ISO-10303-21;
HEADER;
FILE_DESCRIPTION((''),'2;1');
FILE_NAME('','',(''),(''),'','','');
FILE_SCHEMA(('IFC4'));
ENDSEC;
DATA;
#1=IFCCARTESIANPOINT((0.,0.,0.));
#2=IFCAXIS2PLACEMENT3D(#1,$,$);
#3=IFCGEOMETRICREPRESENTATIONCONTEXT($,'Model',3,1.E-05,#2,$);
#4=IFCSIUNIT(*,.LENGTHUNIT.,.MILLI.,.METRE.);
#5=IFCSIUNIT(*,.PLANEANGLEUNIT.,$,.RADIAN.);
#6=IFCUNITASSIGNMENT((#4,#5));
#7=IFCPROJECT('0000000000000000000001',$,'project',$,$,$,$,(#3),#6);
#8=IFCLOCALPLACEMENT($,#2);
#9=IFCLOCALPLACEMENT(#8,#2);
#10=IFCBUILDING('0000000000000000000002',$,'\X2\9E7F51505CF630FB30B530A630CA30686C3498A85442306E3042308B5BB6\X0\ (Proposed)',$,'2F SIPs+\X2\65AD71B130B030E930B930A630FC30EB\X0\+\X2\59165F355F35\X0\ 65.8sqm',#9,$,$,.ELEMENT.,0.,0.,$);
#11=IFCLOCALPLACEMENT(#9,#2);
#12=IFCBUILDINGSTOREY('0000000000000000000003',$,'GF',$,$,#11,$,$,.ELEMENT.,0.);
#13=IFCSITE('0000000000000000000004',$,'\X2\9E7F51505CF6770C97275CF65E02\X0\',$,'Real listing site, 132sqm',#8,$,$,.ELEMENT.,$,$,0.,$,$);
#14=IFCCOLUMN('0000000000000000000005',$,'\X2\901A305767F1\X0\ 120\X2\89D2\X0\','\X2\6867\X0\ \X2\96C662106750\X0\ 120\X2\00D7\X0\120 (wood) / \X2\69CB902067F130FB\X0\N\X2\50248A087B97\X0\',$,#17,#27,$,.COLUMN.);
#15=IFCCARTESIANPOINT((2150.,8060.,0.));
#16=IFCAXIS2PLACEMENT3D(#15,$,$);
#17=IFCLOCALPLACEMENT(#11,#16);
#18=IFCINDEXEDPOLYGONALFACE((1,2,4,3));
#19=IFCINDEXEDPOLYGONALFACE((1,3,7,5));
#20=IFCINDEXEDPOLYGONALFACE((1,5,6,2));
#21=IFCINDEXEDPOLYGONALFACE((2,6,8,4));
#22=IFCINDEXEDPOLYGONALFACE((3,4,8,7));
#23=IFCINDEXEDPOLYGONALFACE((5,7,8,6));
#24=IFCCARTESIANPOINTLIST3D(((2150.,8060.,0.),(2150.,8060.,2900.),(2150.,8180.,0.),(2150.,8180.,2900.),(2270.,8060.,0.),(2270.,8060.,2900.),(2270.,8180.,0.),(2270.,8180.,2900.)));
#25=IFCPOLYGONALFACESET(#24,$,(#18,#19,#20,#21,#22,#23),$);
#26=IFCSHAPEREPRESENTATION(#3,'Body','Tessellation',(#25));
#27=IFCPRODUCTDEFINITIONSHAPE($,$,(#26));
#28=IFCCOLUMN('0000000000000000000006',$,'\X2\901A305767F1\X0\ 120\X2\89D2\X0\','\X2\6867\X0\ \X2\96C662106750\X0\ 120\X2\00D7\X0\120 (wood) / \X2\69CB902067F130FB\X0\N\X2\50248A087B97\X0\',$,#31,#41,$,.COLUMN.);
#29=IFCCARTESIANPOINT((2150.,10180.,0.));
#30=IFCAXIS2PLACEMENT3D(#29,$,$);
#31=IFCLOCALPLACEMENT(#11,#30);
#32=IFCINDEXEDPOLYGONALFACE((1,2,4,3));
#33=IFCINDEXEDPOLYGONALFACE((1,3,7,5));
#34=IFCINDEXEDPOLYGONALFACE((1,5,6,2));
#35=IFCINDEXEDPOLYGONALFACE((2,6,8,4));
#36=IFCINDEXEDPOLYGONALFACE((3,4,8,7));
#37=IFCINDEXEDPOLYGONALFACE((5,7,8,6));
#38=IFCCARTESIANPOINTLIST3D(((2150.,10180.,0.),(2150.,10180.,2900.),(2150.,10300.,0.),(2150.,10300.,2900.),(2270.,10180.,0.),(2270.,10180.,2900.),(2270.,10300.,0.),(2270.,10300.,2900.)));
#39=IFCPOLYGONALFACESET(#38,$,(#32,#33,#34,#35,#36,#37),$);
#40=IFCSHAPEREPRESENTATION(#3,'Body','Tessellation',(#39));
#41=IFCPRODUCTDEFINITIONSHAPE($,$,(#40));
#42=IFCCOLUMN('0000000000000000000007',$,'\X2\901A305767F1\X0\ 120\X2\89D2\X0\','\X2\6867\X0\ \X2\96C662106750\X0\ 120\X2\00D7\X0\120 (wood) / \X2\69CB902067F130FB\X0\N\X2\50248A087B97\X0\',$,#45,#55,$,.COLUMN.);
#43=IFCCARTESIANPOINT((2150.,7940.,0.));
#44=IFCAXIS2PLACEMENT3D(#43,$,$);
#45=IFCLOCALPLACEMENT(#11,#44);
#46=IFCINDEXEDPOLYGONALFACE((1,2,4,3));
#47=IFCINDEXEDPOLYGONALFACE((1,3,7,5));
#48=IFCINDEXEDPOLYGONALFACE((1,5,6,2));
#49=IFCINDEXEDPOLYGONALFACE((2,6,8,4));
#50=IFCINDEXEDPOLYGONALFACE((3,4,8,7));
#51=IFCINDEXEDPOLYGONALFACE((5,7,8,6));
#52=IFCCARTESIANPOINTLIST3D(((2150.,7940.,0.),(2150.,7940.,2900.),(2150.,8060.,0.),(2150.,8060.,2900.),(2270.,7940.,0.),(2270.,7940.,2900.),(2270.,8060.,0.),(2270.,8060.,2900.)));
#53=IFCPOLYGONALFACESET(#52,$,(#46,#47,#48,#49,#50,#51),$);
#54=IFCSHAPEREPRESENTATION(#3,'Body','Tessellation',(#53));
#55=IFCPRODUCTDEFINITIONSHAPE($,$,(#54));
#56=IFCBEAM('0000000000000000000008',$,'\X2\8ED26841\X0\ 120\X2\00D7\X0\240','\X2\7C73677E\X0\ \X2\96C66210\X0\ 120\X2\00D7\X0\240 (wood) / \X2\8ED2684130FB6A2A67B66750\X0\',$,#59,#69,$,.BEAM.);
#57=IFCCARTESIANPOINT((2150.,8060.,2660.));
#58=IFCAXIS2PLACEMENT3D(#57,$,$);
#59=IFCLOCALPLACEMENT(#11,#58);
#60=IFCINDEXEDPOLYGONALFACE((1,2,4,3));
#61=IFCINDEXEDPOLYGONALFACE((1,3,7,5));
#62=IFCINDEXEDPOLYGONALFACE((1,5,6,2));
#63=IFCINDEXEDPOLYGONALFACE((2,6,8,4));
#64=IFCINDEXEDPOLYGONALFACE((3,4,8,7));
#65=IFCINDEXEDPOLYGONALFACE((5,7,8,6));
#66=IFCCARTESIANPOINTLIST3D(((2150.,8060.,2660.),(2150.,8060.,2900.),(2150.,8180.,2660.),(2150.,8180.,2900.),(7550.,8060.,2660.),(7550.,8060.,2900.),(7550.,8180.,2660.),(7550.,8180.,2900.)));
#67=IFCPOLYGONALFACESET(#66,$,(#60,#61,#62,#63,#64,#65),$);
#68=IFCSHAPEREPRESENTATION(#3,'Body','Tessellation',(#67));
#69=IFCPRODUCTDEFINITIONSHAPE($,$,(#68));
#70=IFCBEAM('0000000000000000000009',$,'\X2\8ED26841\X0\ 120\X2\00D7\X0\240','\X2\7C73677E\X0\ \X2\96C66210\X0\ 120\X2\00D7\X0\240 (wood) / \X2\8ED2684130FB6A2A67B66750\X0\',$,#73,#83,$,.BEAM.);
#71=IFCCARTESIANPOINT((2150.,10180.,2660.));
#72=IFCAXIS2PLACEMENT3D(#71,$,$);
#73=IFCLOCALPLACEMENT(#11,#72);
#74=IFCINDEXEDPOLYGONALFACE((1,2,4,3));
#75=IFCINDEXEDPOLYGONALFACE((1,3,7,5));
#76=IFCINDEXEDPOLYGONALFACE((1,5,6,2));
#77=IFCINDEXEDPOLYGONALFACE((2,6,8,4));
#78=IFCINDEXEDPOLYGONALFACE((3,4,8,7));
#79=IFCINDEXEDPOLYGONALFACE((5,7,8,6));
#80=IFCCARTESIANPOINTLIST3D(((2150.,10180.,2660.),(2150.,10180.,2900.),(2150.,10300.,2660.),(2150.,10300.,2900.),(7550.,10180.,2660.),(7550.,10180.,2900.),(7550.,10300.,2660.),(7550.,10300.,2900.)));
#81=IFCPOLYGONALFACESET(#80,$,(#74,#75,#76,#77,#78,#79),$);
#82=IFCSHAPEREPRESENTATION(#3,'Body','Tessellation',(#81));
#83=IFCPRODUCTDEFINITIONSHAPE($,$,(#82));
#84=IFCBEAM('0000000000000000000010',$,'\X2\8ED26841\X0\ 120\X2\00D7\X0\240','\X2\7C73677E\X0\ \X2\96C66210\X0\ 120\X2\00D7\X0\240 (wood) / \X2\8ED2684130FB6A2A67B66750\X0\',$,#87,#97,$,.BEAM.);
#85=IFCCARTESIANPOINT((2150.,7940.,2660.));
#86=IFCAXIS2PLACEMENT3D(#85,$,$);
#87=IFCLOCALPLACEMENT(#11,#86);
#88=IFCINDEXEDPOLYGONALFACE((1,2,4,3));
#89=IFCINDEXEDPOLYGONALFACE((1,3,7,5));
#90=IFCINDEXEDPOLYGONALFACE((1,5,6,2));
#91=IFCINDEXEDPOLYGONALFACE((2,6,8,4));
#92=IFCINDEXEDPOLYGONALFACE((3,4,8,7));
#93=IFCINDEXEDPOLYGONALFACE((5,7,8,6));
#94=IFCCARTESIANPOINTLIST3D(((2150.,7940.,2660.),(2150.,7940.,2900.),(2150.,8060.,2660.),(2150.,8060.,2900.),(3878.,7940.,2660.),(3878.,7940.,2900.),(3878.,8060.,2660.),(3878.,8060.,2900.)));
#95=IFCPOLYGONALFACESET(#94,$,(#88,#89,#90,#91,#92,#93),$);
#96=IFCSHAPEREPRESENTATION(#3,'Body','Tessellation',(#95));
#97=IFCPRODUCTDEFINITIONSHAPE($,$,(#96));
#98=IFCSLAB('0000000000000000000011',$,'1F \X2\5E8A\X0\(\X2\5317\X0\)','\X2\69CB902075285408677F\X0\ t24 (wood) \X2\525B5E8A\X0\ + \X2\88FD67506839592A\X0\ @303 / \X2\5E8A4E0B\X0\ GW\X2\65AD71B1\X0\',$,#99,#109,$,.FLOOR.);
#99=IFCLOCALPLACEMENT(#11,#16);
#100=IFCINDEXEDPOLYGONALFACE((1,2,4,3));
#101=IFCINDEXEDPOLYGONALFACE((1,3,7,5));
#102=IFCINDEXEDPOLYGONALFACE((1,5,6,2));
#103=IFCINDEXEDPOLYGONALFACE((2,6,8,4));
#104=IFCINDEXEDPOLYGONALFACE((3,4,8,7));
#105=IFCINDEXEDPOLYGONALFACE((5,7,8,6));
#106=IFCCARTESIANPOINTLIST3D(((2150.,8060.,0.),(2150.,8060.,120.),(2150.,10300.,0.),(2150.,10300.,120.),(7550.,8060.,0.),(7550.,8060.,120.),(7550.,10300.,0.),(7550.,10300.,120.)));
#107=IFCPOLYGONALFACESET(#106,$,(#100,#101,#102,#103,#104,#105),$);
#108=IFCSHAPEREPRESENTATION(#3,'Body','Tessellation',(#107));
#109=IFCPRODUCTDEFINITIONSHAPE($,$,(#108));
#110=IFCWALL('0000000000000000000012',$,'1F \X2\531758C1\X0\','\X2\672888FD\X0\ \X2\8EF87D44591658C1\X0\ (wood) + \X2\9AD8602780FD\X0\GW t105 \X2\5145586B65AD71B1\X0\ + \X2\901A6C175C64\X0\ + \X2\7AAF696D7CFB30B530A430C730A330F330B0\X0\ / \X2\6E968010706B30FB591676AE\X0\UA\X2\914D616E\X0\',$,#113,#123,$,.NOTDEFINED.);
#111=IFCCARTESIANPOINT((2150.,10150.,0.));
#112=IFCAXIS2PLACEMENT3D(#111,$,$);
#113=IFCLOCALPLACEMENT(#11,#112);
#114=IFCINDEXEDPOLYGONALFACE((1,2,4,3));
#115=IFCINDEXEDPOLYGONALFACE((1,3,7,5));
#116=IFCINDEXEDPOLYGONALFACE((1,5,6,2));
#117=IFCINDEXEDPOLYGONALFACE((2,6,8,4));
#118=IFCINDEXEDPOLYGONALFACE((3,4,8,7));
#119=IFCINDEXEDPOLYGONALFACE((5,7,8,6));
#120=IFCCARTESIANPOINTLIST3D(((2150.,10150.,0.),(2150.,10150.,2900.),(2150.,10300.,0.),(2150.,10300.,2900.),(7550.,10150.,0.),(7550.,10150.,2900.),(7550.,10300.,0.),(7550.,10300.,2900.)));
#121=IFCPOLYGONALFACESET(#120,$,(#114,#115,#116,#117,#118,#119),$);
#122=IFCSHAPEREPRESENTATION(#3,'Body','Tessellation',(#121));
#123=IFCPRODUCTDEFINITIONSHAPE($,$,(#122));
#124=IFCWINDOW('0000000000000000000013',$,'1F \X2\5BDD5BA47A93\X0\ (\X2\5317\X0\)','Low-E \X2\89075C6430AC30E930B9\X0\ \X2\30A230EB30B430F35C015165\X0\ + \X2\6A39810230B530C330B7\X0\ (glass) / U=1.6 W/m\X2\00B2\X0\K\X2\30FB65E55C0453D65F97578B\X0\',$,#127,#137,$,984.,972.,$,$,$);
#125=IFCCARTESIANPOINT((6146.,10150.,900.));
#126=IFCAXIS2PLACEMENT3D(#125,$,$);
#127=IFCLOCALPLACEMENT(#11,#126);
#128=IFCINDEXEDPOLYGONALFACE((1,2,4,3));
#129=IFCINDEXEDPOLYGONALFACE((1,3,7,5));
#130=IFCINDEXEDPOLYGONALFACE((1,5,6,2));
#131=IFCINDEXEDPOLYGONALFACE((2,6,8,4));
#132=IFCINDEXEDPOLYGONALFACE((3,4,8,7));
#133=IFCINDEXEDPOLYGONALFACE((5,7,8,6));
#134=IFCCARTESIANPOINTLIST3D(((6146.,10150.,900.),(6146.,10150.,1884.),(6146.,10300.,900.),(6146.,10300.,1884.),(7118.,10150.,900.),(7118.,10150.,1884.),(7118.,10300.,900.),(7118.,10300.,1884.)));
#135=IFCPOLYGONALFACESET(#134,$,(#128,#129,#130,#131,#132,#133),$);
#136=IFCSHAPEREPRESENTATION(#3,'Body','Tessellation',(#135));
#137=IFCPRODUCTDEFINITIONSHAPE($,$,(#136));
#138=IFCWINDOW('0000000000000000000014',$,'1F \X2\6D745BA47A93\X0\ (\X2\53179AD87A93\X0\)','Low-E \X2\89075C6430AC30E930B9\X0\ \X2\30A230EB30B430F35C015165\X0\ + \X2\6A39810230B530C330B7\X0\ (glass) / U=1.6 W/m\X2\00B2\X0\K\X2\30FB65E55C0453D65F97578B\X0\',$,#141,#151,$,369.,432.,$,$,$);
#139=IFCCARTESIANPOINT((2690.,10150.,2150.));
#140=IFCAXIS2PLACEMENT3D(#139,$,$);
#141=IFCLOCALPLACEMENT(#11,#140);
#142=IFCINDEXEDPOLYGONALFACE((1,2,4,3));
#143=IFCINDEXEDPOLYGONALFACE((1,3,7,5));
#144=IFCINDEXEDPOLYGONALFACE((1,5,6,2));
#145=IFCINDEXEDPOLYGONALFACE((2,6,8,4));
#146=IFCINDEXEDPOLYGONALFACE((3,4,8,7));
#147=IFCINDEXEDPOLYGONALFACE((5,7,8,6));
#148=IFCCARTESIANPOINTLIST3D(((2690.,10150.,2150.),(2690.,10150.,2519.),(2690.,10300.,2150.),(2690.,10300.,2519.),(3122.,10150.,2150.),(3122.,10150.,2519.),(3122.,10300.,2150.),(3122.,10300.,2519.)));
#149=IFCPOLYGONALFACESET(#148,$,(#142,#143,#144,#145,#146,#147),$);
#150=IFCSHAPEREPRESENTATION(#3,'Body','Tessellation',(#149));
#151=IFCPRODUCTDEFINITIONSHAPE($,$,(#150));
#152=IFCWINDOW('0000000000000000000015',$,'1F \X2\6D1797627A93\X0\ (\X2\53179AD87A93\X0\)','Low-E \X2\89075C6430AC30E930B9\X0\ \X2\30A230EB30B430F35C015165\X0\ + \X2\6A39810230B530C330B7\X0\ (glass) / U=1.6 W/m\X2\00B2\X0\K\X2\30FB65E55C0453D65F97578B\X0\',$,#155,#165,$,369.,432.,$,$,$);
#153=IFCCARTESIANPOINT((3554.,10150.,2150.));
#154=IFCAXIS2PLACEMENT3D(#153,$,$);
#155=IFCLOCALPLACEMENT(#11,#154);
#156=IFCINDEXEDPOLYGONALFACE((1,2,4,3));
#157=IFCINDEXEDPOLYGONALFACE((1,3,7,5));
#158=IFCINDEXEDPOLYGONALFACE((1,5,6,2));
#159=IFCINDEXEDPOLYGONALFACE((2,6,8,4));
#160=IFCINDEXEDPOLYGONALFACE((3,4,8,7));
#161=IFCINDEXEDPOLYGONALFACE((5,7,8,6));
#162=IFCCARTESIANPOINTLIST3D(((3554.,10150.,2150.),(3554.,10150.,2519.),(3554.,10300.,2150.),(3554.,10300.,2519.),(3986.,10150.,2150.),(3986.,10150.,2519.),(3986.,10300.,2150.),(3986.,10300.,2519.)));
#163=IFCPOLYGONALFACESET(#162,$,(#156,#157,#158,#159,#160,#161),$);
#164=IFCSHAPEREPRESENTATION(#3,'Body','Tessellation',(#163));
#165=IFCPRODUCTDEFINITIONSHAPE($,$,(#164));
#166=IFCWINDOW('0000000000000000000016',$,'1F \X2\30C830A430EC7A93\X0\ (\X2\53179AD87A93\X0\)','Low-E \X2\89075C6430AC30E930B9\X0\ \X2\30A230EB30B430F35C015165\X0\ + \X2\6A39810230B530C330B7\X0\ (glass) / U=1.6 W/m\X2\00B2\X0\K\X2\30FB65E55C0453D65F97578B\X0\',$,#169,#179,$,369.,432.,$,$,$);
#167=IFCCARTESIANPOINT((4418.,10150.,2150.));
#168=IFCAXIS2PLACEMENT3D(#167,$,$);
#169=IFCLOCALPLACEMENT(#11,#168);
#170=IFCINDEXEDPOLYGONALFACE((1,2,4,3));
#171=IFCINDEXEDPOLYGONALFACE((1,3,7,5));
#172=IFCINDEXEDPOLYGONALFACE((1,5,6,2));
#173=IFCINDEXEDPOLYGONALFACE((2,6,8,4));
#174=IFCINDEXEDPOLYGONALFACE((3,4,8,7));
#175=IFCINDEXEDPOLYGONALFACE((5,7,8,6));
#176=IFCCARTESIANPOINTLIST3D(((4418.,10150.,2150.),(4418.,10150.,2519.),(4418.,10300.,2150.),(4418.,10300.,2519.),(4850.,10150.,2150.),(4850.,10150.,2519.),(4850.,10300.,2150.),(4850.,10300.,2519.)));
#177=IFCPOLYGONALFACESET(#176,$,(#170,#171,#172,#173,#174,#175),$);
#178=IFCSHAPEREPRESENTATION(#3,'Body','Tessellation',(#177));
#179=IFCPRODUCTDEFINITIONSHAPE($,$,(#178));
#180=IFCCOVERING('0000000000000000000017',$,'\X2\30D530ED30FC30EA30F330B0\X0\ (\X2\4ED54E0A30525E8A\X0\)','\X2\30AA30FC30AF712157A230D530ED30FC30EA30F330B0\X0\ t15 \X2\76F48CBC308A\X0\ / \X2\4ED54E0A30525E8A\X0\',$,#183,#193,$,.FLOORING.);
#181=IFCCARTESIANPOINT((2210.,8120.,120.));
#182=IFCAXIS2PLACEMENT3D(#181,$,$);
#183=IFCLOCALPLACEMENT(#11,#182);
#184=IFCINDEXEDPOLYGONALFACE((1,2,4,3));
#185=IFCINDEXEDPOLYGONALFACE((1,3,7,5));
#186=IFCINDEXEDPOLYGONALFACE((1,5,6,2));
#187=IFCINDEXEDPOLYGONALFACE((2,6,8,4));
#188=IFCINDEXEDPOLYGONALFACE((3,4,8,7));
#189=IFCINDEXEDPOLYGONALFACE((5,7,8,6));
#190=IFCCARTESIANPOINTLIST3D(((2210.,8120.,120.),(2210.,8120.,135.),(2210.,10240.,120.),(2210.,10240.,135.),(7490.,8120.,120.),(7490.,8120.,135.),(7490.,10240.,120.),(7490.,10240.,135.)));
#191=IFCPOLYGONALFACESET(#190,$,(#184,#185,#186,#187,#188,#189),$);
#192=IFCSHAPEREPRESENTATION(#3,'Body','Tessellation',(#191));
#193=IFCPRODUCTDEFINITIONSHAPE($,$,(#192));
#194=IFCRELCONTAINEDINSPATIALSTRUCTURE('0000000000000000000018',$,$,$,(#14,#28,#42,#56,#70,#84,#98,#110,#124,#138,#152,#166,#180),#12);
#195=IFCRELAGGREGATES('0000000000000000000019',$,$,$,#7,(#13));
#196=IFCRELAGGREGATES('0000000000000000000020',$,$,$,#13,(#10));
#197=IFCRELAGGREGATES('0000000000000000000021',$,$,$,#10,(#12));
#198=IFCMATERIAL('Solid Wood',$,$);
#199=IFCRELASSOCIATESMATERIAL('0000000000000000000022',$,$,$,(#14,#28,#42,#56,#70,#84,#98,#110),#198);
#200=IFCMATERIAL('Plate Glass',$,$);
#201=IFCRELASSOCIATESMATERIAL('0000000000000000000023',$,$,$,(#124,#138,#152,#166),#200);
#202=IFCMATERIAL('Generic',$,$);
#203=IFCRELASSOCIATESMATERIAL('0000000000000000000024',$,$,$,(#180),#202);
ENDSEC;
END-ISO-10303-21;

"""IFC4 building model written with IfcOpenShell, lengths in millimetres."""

from ifc_helpers import new_model, si_unit, frame, frame_2d, origin, place, context, project, spatial, rectangle, extrude, material, element, fill, save


model = new_model("IFC4")

# Units and contexts
model_context = context("Model", 3, precision=1e-05, world=origin())
ifc_project = project(units=[si_unit("LENGTHUNIT", "METRE", prefix="MILLI"), si_unit("PLANEANGLEUNIT", "RADIAN")], contexts=[model_context])

# Site, building, storey
site_placement = place(None, origin())
site = spatial("IfcSite", under=ifc_project, at=site_placement, Name="鹿児島県霧島市", ObjectType="Real listing site, 132sqm", CompositionType="ELEMENT", RefElevation=0.0)
building_placement = place(site_placement, origin())
building = spatial("IfcBuilding", under=site, at=building_placement, Name="鹿児島・サウナと水風呂のある家 (Proposed)", ObjectType="2F SIPs+断熱グラスウール+外張張 65.8sqm", CompositionType="ELEMENT", ElevationOfRefHeight=0.0, ElevationOfTerrain=0.0)
storey_placement = place(building_placement, origin())
storey = spatial("IfcBuildingStorey", under=building, at=storey_placement, Name="GF", CompositionType="ELEMENT", Elevation=0.0)

# Columns
ifc_material_1 = material(Name="Solid Wood")
column_1_placement = place(storey_placement, frame((2150.0, 8060.0, 0.0)))
element("IfcColumn", 1, at=column_1_placement, inside=storey, material=ifc_material_1, Name="通し柱 120角", Description="桧 集成材 120×120 (wood) / 構造柱・N値計算", PredefinedType="COLUMN", context=model_context, shape_type="SweptSolid", body=[
    extrude(rectangle(XDim=120.0, YDim=120.0, at=frame_2d((60.0, 60.0))), frame((2150.0, 8060.0, 0.0)), (0.0, 0.0, 1.0), 2900.0),
])
column_2_placement = place(storey_placement, frame((2150.0, 10180.0, 0.0)))
element("IfcColumn", 2, at=column_2_placement, inside=storey, material=ifc_material_1, Name="通し柱 120角", Description="桧 集成材 120×120 (wood) / 構造柱・N値計算", PredefinedType="COLUMN", context=model_context, shape_type="SweptSolid", body=[
    extrude(rectangle(XDim=120.0, YDim=120.0, at=frame_2d((60.0, 60.0))), frame((2150.0, 10180.0, 0.0)), (0.0, 0.0, 1.0), 2900.0),
])
column_3_placement = place(storey_placement, frame((2150.0, 7940.0, 0.0)))
element("IfcColumn", 3, at=column_3_placement, inside=storey, material=ifc_material_1, Name="通し柱 120角", Description="桧 集成材 120×120 (wood) / 構造柱・N値計算", PredefinedType="COLUMN", context=model_context, shape_type="SweptSolid", body=[
    extrude(rectangle(XDim=120.0, YDim=120.0, at=frame_2d((60.0, 60.0))), frame((2150.0, 7940.0, 0.0)), (0.0, 0.0, 1.0), 2900.0),
])

# Beams
beam_1_placement = place(storey_placement, frame((2150.0, 8060.0, 2660.0)))
element("IfcBeam", 4, at=beam_1_placement, inside=storey, material=ifc_material_1, Name="軒桁 120×240", Description="米松 集成 120×240 (wood) / 軒桁・横架材", PredefinedType="BEAM", context=model_context, shape_type="SweptSolid", body=[
    extrude(rectangle(XDim=5400.0, YDim=120.0, at=frame_2d((2700.0, 60.0))), frame((2150.0, 8060.0, 2660.0)), (0.0, 0.0, 1.0), 240.0),
])
beam_2_placement = place(storey_placement, frame((2150.0, 10180.0, 2660.0)))
element("IfcBeam", 5, at=beam_2_placement, inside=storey, material=ifc_material_1, Name="軒桁 120×240", Description="米松 集成 120×240 (wood) / 軒桁・横架材", PredefinedType="BEAM", context=model_context, shape_type="SweptSolid", body=[
    extrude(rectangle(XDim=5400.0, YDim=120.0, at=frame_2d((2700.0, 60.0))), frame((2150.0, 10180.0, 2660.0)), (0.0, 0.0, 1.0), 240.0),
])
beam_3_placement = place(storey_placement, frame((2150.0, 7940.0, 2660.0)))
element("IfcBeam", 6, at=beam_3_placement, inside=storey, material=ifc_material_1, Name="軒桁 120×240", Description="米松 集成 120×240 (wood) / 軒桁・横架材", PredefinedType="BEAM", context=model_context, shape_type="SweptSolid", body=[
    extrude(rectangle(XDim=1728.0, YDim=120.0, at=frame_2d((864.0, 60.0))), frame((2150.0, 7940.0, 2660.0)), (0.0, 0.0, 1.0), 240.0),
])

# Slab
slab_placement = place(storey_placement, frame((2150.0, 8060.0, 0.0)))
element("IfcSlab", 7, at=slab_placement, inside=storey, material=ifc_material_1, Name="1F 床(北)", Description="構造用合板 t24 (wood) 剛床 + 製材根太 @303 / 床下 GW断熱", PredefinedType="FLOOR", context=model_context, shape_type="SweptSolid", body=[
    extrude(rectangle(XDim=5400.0, YDim=2240.0, at=frame_2d((2700.0, 1120.0))), frame((2150.0, 8060.0, 0.0)), (0.0, 0.0, 1.0), 120.0),
])

# Wall, openings, windows
wall_1_placement = place(storey_placement, frame((2150.0, 10150.0, 0.0)))
wall_1 = element("IfcWall", 8, at=wall_1_placement, inside=storey, material=ifc_material_1, Name="1F 北壁", Description="木製 軸組外壁 (wood) + 高性能GW t105 充填断熱 + 通気層 + 窯業系サイディング / 準耐火・外皮UA配慮", PredefinedType="NOTDEFINED", context=model_context, shape_type="SweptSolid", body=[
    extrude(rectangle(XDim=5400.0, YDim=150.0, at=frame_2d((2700.0, 75.0))), frame((2150.0, 10150.0, 0.0)), (0.0, 0.0, 1.0), 2900.0),
])
opening_1_placement = place(storey_placement, frame((6146.0, 10150.0, 900.0)))
opening_1 = element("IfcOpeningElement", 9, at=opening_1_placement, cuts=wall_1, PredefinedType="NOTDEFINED", context=model_context, shape_type="SweptSolid", body=[
    extrude(rectangle(XDim=972.0, YDim=150.0, at=frame_2d((486.0, 75.0))), frame((6146.0, 10150.0, 900.0)), (0.0, 0.0, 1.0), 984.0),
])
opening_2_placement = place(storey_placement, frame((2690.0, 10150.0, 2150.0)))
opening_2 = element("IfcOpeningElement", 10, at=opening_2_placement, cuts=wall_1, PredefinedType="NOTDEFINED", context=model_context, shape_type="SweptSolid", body=[
    extrude(rectangle(XDim=432.0, YDim=150.0, at=frame_2d((216.0, 75.0))), frame((2690.0, 10150.0, 2150.0)), (0.0, 0.0, 1.0), 369.0),
])
opening_3_placement = place(storey_placement, frame((3554.0, 10150.0, 2150.0)))
opening_3 = element("IfcOpeningElement", 11, at=opening_3_placement, cuts=wall_1, PredefinedType="NOTDEFINED", context=model_context, shape_type="SweptSolid", body=[
    extrude(rectangle(XDim=432.0, YDim=150.0, at=frame_2d((216.0, 75.0))), frame((3554.0, 10150.0, 2150.0)), (0.0, 0.0, 1.0), 369.0),
])
opening_4_placement = place(storey_placement, frame((4418.0, 10150.0, 2150.0)))
opening_4 = element("IfcOpeningElement", 12, at=opening_4_placement, cuts=wall_1, PredefinedType="NOTDEFINED", context=model_context, shape_type="SweptSolid", body=[
    extrude(rectangle(XDim=432.0, YDim=150.0, at=frame_2d((216.0, 75.0))), frame((4418.0, 10150.0, 2150.0)), (0.0, 0.0, 1.0), 369.0),
])
ifc_material_2 = material(Name="Plate Glass")
window_1_placement = place(storey_placement, frame((6146.0, 10150.0, 900.0)))
window_1 = element("IfcWindow", 13, at=window_1_placement, inside=storey, material=ifc_material_2, Name="1F 寝室窓 (北)", Description="Low-E 複層ガラス アルゴン封入 + 樹脂サッシ (glass) / U=1.6 W/m²K・日射取得型", OverallHeight=984.0, OverallWidth=972.0, context=model_context, shape_type="SweptSolid", body=[
    extrude(rectangle(XDim=972.0, YDim=150.0, at=frame_2d((486.0, 75.0))), frame((6146.0, 10150.0, 900.0)), (0.0, 0.0, 1.0), 984.0),
])
fill(opening_1, window_1)
window_2_placement = place(storey_placement, frame((2690.0, 10150.0, 2150.0)))
window_2 = element("IfcWindow", 14, at=window_2_placement, inside=storey, material=ifc_material_2, Name="1F 浴室窓 (北高窓)", Description="Low-E 複層ガラス アルゴン封入 + 樹脂サッシ (glass) / U=1.6 W/m²K・日射取得型", OverallHeight=369.0, OverallWidth=432.0, context=model_context, shape_type="SweptSolid", body=[
    extrude(rectangle(XDim=432.0, YDim=150.0, at=frame_2d((216.0, 75.0))), frame((2690.0, 10150.0, 2150.0)), (0.0, 0.0, 1.0), 369.0),
])
fill(opening_2, window_2)
window_3_placement = place(storey_placement, frame((3554.0, 10150.0, 2150.0)))
window_3 = element("IfcWindow", 15, at=window_3_placement, inside=storey, material=ifc_material_2, Name="1F 洗面窓 (北高窓)", Description="Low-E 複層ガラス アルゴン封入 + 樹脂サッシ (glass) / U=1.6 W/m²K・日射取得型", OverallHeight=369.0, OverallWidth=432.0, context=model_context, shape_type="SweptSolid", body=[
    extrude(rectangle(XDim=432.0, YDim=150.0, at=frame_2d((216.0, 75.0))), frame((3554.0, 10150.0, 2150.0)), (0.0, 0.0, 1.0), 369.0),
])
fill(opening_3, window_3)
window_4_placement = place(storey_placement, frame((4418.0, 10150.0, 2150.0)))
window_4 = element("IfcWindow", 16, at=window_4_placement, inside=storey, material=ifc_material_2, Name="1F トイレ窓 (北高窓)", Description="Low-E 複層ガラス アルゴン封入 + 樹脂サッシ (glass) / U=1.6 W/m²K・日射取得型", OverallHeight=369.0, OverallWidth=432.0, context=model_context, shape_type="SweptSolid", body=[
    extrude(rectangle(XDim=432.0, YDim=150.0, at=frame_2d((216.0, 75.0))), frame((4418.0, 10150.0, 2150.0)), (0.0, 0.0, 1.0), 369.0),
])
fill(opening_4, window_4)

# Covering
ifc_material_3 = material(Name="Generic")
covering_1_placement = place(storey_placement, frame((2210.0, 8120.0, 120.0)))
element("IfcCovering", 17, at=covering_1_placement, inside=storey, material=ifc_material_3, Name="フローリング (仕上げ床)", Description="オーク無垢フローリング t15 直貼り / 仕上げ床", PredefinedType="FLOORING", context=model_context, shape_type="SweptSolid", body=[
    extrude(rectangle(XDim=5280.0, YDim=2120.0, at=frame_2d((2640.0, 1060.0))), frame((2210.0, 8120.0, 120.0)), (0.0, 0.0, 1.0), 15.0),
])

save(model, "model.ifc")
